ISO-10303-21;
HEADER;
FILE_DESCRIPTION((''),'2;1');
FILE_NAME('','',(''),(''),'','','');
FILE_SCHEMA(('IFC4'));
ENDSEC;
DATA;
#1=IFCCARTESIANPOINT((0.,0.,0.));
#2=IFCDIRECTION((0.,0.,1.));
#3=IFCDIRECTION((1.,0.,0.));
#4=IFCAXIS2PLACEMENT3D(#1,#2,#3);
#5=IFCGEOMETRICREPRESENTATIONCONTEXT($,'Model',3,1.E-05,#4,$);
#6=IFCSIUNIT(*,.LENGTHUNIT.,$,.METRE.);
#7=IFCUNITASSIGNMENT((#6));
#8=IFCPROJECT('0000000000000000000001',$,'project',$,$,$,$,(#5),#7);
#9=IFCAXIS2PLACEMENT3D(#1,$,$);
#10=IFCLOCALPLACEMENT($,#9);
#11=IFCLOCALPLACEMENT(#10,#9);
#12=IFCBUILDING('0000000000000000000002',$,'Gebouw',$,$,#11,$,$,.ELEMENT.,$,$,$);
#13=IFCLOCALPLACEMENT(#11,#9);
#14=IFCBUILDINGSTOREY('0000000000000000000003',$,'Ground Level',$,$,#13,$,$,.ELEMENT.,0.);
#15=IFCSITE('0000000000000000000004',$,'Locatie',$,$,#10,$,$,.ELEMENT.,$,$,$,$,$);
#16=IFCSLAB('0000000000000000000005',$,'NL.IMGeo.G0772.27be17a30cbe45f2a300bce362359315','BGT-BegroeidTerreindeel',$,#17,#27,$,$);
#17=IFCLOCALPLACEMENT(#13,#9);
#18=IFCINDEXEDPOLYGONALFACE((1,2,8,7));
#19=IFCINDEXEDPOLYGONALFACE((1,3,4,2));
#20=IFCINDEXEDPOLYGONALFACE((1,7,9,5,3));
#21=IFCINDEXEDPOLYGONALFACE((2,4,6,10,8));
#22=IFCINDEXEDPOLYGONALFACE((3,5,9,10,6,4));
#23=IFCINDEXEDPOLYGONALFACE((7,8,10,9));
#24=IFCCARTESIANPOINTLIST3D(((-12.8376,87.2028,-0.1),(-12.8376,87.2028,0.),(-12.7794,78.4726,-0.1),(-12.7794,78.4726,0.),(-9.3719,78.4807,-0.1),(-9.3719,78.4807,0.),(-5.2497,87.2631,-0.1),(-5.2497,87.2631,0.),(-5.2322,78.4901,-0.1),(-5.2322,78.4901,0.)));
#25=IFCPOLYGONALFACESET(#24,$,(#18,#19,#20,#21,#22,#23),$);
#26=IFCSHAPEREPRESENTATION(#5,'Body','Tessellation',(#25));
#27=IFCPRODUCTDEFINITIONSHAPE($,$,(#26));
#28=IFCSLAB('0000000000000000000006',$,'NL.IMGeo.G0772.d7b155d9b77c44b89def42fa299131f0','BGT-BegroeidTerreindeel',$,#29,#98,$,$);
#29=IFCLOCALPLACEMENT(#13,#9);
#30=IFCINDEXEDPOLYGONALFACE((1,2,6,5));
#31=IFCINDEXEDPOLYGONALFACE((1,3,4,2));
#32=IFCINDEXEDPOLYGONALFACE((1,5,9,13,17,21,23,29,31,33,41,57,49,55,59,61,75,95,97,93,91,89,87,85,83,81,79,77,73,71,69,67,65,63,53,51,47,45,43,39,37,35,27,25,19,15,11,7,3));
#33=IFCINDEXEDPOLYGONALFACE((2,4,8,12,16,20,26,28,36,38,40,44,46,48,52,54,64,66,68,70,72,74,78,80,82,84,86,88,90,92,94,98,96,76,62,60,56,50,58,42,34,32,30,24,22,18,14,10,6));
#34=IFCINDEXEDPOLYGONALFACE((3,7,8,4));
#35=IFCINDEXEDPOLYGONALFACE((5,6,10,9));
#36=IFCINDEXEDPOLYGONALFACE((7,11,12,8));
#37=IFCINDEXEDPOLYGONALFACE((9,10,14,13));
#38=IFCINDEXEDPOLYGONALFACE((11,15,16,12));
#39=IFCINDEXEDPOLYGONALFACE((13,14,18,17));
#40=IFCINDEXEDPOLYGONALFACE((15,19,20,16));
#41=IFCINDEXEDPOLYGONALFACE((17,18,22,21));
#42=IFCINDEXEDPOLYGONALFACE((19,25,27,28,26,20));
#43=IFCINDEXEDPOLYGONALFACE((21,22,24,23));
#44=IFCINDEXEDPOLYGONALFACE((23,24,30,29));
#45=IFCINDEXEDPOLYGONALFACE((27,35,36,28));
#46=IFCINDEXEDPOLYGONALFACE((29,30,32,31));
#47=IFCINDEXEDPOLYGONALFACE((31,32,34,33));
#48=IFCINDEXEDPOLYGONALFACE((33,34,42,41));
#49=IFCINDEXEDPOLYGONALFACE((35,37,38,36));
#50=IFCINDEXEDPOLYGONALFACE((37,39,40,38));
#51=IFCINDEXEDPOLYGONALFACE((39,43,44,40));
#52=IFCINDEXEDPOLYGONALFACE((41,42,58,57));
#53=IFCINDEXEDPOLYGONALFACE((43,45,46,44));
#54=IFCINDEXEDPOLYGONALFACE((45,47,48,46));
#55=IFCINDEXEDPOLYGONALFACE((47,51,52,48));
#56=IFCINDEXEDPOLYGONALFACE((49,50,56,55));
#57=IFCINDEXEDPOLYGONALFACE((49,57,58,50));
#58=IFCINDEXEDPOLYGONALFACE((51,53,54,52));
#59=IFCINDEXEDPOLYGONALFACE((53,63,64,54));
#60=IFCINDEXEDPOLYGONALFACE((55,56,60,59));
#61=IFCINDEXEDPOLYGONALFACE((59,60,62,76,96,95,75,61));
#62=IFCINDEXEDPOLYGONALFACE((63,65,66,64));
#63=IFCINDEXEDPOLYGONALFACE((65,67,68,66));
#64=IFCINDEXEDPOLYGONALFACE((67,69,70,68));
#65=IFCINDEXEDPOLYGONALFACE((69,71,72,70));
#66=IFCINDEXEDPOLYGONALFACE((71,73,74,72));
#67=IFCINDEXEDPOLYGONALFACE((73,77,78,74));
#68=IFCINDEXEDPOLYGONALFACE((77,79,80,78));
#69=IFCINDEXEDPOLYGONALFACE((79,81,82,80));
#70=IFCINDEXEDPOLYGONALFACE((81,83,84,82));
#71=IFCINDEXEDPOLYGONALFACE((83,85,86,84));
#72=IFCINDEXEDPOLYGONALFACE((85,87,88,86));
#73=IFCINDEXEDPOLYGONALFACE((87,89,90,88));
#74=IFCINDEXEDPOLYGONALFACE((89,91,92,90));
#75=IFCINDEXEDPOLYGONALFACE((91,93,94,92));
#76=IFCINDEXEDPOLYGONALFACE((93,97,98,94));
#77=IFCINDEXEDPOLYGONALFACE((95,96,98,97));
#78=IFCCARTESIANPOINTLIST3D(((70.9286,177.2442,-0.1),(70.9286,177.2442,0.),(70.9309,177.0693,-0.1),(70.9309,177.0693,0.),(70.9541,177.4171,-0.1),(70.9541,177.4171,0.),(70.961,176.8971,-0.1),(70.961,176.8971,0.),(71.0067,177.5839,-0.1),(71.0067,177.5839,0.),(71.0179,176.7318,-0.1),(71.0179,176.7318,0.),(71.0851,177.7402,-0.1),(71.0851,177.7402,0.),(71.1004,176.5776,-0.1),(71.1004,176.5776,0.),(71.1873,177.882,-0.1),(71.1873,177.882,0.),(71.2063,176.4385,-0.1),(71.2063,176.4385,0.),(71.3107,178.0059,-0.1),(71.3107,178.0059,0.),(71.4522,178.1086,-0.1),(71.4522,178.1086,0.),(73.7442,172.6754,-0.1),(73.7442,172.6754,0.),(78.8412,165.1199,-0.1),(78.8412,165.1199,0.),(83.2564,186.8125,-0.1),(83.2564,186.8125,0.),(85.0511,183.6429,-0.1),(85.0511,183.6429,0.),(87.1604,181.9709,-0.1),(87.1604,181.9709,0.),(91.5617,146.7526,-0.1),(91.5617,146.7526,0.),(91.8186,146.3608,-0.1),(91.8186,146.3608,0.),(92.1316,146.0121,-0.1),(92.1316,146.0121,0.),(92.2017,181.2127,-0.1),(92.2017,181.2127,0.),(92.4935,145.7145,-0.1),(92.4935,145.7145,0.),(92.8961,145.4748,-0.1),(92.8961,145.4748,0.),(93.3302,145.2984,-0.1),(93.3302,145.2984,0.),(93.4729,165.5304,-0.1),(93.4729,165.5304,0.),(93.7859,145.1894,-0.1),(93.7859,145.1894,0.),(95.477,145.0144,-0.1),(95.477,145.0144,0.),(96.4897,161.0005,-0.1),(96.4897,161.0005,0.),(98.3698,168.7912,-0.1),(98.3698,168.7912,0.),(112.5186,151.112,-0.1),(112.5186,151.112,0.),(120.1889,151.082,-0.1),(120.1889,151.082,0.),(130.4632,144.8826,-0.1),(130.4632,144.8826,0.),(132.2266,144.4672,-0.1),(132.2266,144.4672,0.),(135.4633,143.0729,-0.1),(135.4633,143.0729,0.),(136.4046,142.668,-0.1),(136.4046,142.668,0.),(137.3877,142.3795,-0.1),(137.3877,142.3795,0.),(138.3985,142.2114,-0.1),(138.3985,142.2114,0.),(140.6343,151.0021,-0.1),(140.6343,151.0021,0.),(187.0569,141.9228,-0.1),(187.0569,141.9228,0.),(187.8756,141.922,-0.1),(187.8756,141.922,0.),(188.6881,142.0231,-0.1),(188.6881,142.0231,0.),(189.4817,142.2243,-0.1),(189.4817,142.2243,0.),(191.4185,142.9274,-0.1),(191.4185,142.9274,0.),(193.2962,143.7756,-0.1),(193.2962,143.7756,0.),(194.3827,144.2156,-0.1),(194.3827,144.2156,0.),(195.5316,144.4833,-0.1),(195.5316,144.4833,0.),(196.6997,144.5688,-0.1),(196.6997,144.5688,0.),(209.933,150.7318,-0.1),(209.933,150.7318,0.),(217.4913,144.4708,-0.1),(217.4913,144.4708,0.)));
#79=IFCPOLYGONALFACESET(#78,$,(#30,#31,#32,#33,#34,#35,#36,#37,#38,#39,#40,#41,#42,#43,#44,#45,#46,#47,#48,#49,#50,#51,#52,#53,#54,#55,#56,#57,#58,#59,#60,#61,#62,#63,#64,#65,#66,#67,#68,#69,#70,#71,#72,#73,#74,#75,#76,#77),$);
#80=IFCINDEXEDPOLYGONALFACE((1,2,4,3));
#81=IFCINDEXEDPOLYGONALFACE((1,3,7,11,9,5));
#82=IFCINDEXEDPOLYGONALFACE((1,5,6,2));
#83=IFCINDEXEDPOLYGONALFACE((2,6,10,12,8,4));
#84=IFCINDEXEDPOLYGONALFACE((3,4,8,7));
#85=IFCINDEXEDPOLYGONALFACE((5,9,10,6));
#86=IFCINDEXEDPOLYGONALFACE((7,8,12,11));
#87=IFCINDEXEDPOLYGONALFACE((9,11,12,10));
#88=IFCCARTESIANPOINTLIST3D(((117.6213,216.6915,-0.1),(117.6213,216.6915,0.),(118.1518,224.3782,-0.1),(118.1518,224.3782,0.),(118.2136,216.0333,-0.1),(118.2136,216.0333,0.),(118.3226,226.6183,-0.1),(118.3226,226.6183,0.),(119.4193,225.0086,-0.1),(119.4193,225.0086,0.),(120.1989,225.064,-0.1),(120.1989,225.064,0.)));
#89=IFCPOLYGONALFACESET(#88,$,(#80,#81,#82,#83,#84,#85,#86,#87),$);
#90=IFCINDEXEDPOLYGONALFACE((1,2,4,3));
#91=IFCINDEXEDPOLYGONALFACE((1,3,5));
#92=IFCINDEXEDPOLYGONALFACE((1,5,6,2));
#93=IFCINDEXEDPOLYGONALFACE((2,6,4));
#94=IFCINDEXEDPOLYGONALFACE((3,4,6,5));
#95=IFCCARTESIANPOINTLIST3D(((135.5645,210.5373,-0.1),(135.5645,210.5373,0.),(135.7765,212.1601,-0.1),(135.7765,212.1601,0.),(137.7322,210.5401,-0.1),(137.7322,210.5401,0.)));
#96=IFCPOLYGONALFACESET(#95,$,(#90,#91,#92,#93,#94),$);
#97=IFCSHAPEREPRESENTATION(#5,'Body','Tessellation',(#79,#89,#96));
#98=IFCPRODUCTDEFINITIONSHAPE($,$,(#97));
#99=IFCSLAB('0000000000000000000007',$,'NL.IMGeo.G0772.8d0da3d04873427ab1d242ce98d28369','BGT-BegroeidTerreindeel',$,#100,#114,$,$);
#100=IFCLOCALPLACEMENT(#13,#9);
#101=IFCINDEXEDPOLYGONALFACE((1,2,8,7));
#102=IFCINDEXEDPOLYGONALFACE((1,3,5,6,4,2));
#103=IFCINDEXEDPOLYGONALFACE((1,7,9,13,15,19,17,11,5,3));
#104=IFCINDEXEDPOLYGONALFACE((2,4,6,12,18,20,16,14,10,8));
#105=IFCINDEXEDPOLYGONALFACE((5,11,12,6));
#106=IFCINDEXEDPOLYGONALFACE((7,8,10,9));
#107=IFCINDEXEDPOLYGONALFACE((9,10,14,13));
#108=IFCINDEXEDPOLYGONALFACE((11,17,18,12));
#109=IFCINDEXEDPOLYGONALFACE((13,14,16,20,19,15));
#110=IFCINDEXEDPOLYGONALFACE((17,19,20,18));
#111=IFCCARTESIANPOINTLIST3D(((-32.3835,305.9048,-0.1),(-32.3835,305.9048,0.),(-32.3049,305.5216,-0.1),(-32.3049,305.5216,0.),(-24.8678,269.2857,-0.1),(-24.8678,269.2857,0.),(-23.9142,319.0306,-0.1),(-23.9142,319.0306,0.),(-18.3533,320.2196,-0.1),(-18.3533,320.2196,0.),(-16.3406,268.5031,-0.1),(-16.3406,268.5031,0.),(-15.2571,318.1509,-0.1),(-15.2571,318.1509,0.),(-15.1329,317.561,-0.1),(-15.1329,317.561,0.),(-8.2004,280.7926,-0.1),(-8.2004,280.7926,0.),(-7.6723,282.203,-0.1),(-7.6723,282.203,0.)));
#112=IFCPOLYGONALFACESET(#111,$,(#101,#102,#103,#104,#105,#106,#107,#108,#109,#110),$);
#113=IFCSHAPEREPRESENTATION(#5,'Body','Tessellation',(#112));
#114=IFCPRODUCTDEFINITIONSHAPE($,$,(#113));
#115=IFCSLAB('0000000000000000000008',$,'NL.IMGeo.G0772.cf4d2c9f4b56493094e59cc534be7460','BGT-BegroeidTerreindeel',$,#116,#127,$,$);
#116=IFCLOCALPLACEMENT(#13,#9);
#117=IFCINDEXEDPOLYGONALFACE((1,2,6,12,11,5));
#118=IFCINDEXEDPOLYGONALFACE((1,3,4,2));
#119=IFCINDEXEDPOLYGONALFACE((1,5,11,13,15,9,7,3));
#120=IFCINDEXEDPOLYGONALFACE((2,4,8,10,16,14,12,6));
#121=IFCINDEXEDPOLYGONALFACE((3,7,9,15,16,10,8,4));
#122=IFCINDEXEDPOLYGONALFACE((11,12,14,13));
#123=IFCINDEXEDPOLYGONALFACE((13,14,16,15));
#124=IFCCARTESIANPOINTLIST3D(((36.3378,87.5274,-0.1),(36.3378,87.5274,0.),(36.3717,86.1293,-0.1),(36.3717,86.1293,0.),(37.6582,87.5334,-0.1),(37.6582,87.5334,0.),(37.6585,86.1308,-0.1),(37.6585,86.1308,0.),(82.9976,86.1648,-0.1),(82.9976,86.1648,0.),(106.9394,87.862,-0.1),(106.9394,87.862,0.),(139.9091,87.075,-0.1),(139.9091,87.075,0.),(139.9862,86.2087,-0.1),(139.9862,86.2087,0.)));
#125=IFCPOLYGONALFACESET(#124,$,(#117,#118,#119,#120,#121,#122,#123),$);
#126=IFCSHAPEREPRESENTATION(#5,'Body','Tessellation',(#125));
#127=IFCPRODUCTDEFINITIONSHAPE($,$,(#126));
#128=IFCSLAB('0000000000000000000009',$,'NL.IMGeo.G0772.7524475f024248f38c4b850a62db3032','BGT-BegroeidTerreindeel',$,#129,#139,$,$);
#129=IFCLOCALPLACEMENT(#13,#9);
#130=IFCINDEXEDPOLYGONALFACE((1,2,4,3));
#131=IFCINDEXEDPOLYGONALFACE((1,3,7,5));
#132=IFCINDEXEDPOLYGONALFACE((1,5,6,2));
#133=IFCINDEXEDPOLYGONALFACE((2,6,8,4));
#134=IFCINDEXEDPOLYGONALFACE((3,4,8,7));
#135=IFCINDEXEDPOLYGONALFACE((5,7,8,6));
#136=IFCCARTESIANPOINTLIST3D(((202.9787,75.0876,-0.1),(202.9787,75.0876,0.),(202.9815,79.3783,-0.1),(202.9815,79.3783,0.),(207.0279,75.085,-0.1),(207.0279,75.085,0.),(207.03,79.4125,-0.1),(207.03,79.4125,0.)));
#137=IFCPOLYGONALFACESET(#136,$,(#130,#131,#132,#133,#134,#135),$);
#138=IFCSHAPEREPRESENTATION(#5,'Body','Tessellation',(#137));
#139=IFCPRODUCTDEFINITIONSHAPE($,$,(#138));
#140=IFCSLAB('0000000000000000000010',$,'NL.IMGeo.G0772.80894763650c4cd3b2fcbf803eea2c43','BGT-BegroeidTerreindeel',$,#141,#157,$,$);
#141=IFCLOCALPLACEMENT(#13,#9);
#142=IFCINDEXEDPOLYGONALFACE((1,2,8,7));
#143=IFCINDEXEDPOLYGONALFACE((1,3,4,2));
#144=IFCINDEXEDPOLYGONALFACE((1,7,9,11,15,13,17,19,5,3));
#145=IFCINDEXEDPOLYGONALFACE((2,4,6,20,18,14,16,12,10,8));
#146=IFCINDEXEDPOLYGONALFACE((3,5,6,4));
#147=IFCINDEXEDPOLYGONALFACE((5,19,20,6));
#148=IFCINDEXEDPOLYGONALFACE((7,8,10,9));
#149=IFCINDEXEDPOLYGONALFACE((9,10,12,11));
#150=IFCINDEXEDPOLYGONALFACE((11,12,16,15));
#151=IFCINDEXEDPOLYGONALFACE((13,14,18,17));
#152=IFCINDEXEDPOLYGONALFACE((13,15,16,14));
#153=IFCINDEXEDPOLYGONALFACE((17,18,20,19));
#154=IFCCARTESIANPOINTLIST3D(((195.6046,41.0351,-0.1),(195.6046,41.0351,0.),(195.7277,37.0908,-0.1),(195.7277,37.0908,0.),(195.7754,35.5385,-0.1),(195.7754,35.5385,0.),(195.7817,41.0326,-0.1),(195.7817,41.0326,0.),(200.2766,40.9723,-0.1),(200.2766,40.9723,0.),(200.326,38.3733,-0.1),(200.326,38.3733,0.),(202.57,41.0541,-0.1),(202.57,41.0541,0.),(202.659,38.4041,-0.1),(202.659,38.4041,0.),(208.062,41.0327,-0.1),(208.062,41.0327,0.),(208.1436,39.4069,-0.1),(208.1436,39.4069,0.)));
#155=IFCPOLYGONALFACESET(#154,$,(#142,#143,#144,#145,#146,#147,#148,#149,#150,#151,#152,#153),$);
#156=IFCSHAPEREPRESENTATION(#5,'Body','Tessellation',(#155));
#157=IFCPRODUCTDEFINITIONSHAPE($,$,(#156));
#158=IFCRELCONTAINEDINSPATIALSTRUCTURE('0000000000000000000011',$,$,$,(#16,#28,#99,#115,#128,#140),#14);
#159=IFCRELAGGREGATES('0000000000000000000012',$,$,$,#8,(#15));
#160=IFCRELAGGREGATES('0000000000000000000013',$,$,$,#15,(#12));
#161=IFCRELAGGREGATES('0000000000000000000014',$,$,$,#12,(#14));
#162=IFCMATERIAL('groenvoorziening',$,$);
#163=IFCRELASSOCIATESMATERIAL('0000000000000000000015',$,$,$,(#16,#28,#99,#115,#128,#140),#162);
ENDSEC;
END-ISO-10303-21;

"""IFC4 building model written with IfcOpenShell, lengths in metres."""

from ifc_helpers import new_model, si_unit, frame, origin, origin_with_axes, place, context, project, spatial, polyline, outline, extrude, material, element, save


model = new_model("IFC4")

# Units and contexts
model_context = context("Model", 3, precision=1e-05, world=origin_with_axes())
ifc_project = project(units=[si_unit("LENGTHUNIT", "METRE")], contexts=[model_context])

# Site, building, storey
site_placement = place(None, origin())
site = spatial("IfcSite", under=ifc_project, at=site_placement, Name="Locatie", CompositionType="ELEMENT")
building_placement = place(site_placement, origin())
building = spatial("IfcBuilding", under=site, at=building_placement, Name="Gebouw", CompositionType="ELEMENT")
storey_placement = place(building_placement, origin())
storey = spatial("IfcBuildingStorey", under=building, at=storey_placement, Name="Ground Level", CompositionType="ELEMENT", Elevation=0.0)

# Slabs
ifc_material = material(Name="groenvoorziening")
slab_1_placement = place(storey_placement, origin())
element("IfcSlab", 1, at=slab_1_placement, inside=storey, material=ifc_material, Name="NL.IMGeo.G0772.27be17a30cbe45f2a300bce362359315", Description="BGT-BegroeidTerreindeel", context=model_context, shape_type="SweptSolid", body=[
    extrude(outline(polyline([(-5.2497, 87.2631), (-5.2322, 78.4901), (-9.3719, 78.4807), (-12.7794, 78.4726), (-12.8376, 87.2028), (-5.2497, 87.2631)])), frame((0.0, 0.0, -0.1), z_axis=(0.0, 0.0, 1.0), x_axis=(1.0, 0.0, 0.0)), (0.0, 0.0, 1.0), 0.1),
])
slab_2_placement = place(storey_placement, origin())
element("IfcSlab", 2, at=slab_2_placement, inside=storey, material=ifc_material, Name="NL.IMGeo.G0772.d7b155d9b77c44b89def42fa299131f0", Description="BGT-BegroeidTerreindeel", context=model_context, shape_type="SweptSolid", body=[
    extrude(outline(polyline([(196.6997, 144.5688), (195.5316, 144.4833), (194.3827, 144.2156), (193.2962, 143.7756), (191.4185, 142.9274), (189.4817, 142.2243), (188.6881, 142.0231), (187.8756, 141.922), (187.0569, 141.9228), (138.3985, 142.2114), (137.3877, 142.3795), (136.4046, 142.668), (135.4633, 143.0729), (132.2266, 144.4672), (130.4632, 144.8826), (95.477, 145.0144), (93.7859, 145.1894), (93.3302, 145.2984), (92.8961, 145.4748), (92.4935, 145.7145), (92.1316, 146.0121), (91.8186, 146.3608), (91.5617, 146.7526), (78.8412, 165.1199), (73.7442, 172.6754), (71.2063, 176.4385), (71.1004, 176.5776), (71.0179, 176.7318), (70.961, 176.8971), (70.9309, 177.0693), (70.9286, 177.2442), (70.9541, 177.4171), (71.0067, 177.5839), (71.0851, 177.7402), (71.1873, 177.882), (71.3107, 178.0059), (71.4522, 178.1086), (83.2564, 186.8125), (85.0511, 183.6429), (87.1604, 181.9709), (92.2017, 181.2127), (98.3698, 168.7912), (93.4729, 165.5304), (96.4897, 161.0005), (112.5186, 151.112), (120.1889, 151.082), (140.6343, 151.0021), (209.933, 150.7318), (217.4913, 144.4708), (196.6997, 144.5688)])), frame((0.0, 0.0, -0.1), z_axis=(0.0, 0.0, 1.0), x_axis=(1.0, 0.0, 0.0)), (0.0, 0.0, 1.0), 0.1),
    extrude(outline(polyline([(119.4193, 225.0086), (118.2136, 216.0333), (117.6213, 216.6915), (118.1518, 224.3782), (118.3226, 226.6183), (120.1989, 225.064), (119.4193, 225.0086)])), frame((0.0, 0.0, -0.1), z_axis=(0.0, 0.0, 1.0), x_axis=(1.0, 0.0, 0.0)), (0.0, 0.0, 1.0), 0.1),
    extrude(outline(polyline([(135.5645, 210.5373), (135.7765, 212.1601), (137.7322, 210.5401), (135.5645, 210.5373)])), frame((0.0, 0.0, -0.1), z_axis=(0.0, 0.0, 1.0), x_axis=(1.0, 0.0, 0.0)), (0.0, 0.0, 1.0), 0.1),
])
slab_3_placement = place(storey_placement, origin())
element("IfcSlab", 3, at=slab_3_placement, inside=storey, material=ifc_material, Name="NL.IMGeo.G0772.8d0da3d04873427ab1d242ce98d28369", Description="BGT-BegroeidTerreindeel", context=model_context, shape_type="SweptSolid", body=[
    extrude(outline(polyline([(-7.6723, 282.203), (-8.2004, 280.7926), (-16.3406, 268.5031), (-24.8678, 269.2857), (-32.3049, 305.5216), (-32.3835, 305.9048), (-23.9142, 319.0306), (-18.3533, 320.2196), (-15.2571, 318.1509), (-15.1329, 317.561), (-7.6723, 282.203)])), frame((0.0, 0.0, -0.1), z_axis=(0.0, 0.0, 1.0), x_axis=(1.0, 0.0, 0.0)), (0.0, 0.0, 1.0), 0.1),
])
slab_4_placement = place(storey_placement, origin())
element("IfcSlab", 4, at=slab_4_placement, inside=storey, material=ifc_material, Name="NL.IMGeo.G0772.cf4d2c9f4b56493094e59cc534be7460", Description="BGT-BegroeidTerreindeel", context=model_context, shape_type="SweptSolid", body=[
    extrude(outline(polyline([(106.9394, 87.862), (139.9091, 87.075), (139.9862, 86.2087), (82.9976, 86.1648), (37.6585, 86.1308), (36.3717, 86.1293), (36.3378, 87.5274), (37.6582, 87.5334), (106.9394, 87.862)])), frame((0.0, 0.0, -0.1), z_axis=(0.0, 0.0, 1.0), x_axis=(1.0, 0.0, 0.0)), (0.0, 0.0, 1.0), 0.1),
])
slab_5_placement = place(storey_placement, origin())
element("IfcSlab", 5, at=slab_5_placement, inside=storey, material=ifc_material, Name="NL.IMGeo.G0772.7524475f024248f38c4b850a62db3032", Description="BGT-BegroeidTerreindeel", context=model_context, shape_type="SweptSolid", body=[
    extrude(outline(polyline([(207.0279, 75.085), (202.9787, 75.0876), (202.9815, 79.3783), (207.03, 79.4125), (207.0279, 75.085)])), frame((0.0, 0.0, -0.1), z_axis=(0.0, 0.0, 1.0), x_axis=(1.0, 0.0, 0.0)), (0.0, 0.0, 1.0), 0.1),
])
slab_6_placement = place(storey_placement, origin())
element("IfcSlab", 6, at=slab_6_placement, inside=storey, material=ifc_material, Name="NL.IMGeo.G0772.80894763650c4cd3b2fcbf803eea2c43", Description="BGT-BegroeidTerreindeel", context=model_context, shape_type="SweptSolid", body=[
    extrude(outline(polyline([(200.326, 38.3733), (202.659, 38.4041), (202.57, 41.0541), (208.062, 41.0327), (208.1436, 39.4069), (195.7754, 35.5385), (195.7277, 37.0908), (195.6046, 41.0351), (195.7817, 41.0326), (200.2766, 40.9723), (200.326, 38.3733)])), frame((0.0, 0.0, -0.1), z_axis=(0.0, 0.0, 1.0), x_axis=(1.0, 0.0, 0.0)), (0.0, 0.0, 1.0), 0.1),
])

save(model, "model.ifc")
